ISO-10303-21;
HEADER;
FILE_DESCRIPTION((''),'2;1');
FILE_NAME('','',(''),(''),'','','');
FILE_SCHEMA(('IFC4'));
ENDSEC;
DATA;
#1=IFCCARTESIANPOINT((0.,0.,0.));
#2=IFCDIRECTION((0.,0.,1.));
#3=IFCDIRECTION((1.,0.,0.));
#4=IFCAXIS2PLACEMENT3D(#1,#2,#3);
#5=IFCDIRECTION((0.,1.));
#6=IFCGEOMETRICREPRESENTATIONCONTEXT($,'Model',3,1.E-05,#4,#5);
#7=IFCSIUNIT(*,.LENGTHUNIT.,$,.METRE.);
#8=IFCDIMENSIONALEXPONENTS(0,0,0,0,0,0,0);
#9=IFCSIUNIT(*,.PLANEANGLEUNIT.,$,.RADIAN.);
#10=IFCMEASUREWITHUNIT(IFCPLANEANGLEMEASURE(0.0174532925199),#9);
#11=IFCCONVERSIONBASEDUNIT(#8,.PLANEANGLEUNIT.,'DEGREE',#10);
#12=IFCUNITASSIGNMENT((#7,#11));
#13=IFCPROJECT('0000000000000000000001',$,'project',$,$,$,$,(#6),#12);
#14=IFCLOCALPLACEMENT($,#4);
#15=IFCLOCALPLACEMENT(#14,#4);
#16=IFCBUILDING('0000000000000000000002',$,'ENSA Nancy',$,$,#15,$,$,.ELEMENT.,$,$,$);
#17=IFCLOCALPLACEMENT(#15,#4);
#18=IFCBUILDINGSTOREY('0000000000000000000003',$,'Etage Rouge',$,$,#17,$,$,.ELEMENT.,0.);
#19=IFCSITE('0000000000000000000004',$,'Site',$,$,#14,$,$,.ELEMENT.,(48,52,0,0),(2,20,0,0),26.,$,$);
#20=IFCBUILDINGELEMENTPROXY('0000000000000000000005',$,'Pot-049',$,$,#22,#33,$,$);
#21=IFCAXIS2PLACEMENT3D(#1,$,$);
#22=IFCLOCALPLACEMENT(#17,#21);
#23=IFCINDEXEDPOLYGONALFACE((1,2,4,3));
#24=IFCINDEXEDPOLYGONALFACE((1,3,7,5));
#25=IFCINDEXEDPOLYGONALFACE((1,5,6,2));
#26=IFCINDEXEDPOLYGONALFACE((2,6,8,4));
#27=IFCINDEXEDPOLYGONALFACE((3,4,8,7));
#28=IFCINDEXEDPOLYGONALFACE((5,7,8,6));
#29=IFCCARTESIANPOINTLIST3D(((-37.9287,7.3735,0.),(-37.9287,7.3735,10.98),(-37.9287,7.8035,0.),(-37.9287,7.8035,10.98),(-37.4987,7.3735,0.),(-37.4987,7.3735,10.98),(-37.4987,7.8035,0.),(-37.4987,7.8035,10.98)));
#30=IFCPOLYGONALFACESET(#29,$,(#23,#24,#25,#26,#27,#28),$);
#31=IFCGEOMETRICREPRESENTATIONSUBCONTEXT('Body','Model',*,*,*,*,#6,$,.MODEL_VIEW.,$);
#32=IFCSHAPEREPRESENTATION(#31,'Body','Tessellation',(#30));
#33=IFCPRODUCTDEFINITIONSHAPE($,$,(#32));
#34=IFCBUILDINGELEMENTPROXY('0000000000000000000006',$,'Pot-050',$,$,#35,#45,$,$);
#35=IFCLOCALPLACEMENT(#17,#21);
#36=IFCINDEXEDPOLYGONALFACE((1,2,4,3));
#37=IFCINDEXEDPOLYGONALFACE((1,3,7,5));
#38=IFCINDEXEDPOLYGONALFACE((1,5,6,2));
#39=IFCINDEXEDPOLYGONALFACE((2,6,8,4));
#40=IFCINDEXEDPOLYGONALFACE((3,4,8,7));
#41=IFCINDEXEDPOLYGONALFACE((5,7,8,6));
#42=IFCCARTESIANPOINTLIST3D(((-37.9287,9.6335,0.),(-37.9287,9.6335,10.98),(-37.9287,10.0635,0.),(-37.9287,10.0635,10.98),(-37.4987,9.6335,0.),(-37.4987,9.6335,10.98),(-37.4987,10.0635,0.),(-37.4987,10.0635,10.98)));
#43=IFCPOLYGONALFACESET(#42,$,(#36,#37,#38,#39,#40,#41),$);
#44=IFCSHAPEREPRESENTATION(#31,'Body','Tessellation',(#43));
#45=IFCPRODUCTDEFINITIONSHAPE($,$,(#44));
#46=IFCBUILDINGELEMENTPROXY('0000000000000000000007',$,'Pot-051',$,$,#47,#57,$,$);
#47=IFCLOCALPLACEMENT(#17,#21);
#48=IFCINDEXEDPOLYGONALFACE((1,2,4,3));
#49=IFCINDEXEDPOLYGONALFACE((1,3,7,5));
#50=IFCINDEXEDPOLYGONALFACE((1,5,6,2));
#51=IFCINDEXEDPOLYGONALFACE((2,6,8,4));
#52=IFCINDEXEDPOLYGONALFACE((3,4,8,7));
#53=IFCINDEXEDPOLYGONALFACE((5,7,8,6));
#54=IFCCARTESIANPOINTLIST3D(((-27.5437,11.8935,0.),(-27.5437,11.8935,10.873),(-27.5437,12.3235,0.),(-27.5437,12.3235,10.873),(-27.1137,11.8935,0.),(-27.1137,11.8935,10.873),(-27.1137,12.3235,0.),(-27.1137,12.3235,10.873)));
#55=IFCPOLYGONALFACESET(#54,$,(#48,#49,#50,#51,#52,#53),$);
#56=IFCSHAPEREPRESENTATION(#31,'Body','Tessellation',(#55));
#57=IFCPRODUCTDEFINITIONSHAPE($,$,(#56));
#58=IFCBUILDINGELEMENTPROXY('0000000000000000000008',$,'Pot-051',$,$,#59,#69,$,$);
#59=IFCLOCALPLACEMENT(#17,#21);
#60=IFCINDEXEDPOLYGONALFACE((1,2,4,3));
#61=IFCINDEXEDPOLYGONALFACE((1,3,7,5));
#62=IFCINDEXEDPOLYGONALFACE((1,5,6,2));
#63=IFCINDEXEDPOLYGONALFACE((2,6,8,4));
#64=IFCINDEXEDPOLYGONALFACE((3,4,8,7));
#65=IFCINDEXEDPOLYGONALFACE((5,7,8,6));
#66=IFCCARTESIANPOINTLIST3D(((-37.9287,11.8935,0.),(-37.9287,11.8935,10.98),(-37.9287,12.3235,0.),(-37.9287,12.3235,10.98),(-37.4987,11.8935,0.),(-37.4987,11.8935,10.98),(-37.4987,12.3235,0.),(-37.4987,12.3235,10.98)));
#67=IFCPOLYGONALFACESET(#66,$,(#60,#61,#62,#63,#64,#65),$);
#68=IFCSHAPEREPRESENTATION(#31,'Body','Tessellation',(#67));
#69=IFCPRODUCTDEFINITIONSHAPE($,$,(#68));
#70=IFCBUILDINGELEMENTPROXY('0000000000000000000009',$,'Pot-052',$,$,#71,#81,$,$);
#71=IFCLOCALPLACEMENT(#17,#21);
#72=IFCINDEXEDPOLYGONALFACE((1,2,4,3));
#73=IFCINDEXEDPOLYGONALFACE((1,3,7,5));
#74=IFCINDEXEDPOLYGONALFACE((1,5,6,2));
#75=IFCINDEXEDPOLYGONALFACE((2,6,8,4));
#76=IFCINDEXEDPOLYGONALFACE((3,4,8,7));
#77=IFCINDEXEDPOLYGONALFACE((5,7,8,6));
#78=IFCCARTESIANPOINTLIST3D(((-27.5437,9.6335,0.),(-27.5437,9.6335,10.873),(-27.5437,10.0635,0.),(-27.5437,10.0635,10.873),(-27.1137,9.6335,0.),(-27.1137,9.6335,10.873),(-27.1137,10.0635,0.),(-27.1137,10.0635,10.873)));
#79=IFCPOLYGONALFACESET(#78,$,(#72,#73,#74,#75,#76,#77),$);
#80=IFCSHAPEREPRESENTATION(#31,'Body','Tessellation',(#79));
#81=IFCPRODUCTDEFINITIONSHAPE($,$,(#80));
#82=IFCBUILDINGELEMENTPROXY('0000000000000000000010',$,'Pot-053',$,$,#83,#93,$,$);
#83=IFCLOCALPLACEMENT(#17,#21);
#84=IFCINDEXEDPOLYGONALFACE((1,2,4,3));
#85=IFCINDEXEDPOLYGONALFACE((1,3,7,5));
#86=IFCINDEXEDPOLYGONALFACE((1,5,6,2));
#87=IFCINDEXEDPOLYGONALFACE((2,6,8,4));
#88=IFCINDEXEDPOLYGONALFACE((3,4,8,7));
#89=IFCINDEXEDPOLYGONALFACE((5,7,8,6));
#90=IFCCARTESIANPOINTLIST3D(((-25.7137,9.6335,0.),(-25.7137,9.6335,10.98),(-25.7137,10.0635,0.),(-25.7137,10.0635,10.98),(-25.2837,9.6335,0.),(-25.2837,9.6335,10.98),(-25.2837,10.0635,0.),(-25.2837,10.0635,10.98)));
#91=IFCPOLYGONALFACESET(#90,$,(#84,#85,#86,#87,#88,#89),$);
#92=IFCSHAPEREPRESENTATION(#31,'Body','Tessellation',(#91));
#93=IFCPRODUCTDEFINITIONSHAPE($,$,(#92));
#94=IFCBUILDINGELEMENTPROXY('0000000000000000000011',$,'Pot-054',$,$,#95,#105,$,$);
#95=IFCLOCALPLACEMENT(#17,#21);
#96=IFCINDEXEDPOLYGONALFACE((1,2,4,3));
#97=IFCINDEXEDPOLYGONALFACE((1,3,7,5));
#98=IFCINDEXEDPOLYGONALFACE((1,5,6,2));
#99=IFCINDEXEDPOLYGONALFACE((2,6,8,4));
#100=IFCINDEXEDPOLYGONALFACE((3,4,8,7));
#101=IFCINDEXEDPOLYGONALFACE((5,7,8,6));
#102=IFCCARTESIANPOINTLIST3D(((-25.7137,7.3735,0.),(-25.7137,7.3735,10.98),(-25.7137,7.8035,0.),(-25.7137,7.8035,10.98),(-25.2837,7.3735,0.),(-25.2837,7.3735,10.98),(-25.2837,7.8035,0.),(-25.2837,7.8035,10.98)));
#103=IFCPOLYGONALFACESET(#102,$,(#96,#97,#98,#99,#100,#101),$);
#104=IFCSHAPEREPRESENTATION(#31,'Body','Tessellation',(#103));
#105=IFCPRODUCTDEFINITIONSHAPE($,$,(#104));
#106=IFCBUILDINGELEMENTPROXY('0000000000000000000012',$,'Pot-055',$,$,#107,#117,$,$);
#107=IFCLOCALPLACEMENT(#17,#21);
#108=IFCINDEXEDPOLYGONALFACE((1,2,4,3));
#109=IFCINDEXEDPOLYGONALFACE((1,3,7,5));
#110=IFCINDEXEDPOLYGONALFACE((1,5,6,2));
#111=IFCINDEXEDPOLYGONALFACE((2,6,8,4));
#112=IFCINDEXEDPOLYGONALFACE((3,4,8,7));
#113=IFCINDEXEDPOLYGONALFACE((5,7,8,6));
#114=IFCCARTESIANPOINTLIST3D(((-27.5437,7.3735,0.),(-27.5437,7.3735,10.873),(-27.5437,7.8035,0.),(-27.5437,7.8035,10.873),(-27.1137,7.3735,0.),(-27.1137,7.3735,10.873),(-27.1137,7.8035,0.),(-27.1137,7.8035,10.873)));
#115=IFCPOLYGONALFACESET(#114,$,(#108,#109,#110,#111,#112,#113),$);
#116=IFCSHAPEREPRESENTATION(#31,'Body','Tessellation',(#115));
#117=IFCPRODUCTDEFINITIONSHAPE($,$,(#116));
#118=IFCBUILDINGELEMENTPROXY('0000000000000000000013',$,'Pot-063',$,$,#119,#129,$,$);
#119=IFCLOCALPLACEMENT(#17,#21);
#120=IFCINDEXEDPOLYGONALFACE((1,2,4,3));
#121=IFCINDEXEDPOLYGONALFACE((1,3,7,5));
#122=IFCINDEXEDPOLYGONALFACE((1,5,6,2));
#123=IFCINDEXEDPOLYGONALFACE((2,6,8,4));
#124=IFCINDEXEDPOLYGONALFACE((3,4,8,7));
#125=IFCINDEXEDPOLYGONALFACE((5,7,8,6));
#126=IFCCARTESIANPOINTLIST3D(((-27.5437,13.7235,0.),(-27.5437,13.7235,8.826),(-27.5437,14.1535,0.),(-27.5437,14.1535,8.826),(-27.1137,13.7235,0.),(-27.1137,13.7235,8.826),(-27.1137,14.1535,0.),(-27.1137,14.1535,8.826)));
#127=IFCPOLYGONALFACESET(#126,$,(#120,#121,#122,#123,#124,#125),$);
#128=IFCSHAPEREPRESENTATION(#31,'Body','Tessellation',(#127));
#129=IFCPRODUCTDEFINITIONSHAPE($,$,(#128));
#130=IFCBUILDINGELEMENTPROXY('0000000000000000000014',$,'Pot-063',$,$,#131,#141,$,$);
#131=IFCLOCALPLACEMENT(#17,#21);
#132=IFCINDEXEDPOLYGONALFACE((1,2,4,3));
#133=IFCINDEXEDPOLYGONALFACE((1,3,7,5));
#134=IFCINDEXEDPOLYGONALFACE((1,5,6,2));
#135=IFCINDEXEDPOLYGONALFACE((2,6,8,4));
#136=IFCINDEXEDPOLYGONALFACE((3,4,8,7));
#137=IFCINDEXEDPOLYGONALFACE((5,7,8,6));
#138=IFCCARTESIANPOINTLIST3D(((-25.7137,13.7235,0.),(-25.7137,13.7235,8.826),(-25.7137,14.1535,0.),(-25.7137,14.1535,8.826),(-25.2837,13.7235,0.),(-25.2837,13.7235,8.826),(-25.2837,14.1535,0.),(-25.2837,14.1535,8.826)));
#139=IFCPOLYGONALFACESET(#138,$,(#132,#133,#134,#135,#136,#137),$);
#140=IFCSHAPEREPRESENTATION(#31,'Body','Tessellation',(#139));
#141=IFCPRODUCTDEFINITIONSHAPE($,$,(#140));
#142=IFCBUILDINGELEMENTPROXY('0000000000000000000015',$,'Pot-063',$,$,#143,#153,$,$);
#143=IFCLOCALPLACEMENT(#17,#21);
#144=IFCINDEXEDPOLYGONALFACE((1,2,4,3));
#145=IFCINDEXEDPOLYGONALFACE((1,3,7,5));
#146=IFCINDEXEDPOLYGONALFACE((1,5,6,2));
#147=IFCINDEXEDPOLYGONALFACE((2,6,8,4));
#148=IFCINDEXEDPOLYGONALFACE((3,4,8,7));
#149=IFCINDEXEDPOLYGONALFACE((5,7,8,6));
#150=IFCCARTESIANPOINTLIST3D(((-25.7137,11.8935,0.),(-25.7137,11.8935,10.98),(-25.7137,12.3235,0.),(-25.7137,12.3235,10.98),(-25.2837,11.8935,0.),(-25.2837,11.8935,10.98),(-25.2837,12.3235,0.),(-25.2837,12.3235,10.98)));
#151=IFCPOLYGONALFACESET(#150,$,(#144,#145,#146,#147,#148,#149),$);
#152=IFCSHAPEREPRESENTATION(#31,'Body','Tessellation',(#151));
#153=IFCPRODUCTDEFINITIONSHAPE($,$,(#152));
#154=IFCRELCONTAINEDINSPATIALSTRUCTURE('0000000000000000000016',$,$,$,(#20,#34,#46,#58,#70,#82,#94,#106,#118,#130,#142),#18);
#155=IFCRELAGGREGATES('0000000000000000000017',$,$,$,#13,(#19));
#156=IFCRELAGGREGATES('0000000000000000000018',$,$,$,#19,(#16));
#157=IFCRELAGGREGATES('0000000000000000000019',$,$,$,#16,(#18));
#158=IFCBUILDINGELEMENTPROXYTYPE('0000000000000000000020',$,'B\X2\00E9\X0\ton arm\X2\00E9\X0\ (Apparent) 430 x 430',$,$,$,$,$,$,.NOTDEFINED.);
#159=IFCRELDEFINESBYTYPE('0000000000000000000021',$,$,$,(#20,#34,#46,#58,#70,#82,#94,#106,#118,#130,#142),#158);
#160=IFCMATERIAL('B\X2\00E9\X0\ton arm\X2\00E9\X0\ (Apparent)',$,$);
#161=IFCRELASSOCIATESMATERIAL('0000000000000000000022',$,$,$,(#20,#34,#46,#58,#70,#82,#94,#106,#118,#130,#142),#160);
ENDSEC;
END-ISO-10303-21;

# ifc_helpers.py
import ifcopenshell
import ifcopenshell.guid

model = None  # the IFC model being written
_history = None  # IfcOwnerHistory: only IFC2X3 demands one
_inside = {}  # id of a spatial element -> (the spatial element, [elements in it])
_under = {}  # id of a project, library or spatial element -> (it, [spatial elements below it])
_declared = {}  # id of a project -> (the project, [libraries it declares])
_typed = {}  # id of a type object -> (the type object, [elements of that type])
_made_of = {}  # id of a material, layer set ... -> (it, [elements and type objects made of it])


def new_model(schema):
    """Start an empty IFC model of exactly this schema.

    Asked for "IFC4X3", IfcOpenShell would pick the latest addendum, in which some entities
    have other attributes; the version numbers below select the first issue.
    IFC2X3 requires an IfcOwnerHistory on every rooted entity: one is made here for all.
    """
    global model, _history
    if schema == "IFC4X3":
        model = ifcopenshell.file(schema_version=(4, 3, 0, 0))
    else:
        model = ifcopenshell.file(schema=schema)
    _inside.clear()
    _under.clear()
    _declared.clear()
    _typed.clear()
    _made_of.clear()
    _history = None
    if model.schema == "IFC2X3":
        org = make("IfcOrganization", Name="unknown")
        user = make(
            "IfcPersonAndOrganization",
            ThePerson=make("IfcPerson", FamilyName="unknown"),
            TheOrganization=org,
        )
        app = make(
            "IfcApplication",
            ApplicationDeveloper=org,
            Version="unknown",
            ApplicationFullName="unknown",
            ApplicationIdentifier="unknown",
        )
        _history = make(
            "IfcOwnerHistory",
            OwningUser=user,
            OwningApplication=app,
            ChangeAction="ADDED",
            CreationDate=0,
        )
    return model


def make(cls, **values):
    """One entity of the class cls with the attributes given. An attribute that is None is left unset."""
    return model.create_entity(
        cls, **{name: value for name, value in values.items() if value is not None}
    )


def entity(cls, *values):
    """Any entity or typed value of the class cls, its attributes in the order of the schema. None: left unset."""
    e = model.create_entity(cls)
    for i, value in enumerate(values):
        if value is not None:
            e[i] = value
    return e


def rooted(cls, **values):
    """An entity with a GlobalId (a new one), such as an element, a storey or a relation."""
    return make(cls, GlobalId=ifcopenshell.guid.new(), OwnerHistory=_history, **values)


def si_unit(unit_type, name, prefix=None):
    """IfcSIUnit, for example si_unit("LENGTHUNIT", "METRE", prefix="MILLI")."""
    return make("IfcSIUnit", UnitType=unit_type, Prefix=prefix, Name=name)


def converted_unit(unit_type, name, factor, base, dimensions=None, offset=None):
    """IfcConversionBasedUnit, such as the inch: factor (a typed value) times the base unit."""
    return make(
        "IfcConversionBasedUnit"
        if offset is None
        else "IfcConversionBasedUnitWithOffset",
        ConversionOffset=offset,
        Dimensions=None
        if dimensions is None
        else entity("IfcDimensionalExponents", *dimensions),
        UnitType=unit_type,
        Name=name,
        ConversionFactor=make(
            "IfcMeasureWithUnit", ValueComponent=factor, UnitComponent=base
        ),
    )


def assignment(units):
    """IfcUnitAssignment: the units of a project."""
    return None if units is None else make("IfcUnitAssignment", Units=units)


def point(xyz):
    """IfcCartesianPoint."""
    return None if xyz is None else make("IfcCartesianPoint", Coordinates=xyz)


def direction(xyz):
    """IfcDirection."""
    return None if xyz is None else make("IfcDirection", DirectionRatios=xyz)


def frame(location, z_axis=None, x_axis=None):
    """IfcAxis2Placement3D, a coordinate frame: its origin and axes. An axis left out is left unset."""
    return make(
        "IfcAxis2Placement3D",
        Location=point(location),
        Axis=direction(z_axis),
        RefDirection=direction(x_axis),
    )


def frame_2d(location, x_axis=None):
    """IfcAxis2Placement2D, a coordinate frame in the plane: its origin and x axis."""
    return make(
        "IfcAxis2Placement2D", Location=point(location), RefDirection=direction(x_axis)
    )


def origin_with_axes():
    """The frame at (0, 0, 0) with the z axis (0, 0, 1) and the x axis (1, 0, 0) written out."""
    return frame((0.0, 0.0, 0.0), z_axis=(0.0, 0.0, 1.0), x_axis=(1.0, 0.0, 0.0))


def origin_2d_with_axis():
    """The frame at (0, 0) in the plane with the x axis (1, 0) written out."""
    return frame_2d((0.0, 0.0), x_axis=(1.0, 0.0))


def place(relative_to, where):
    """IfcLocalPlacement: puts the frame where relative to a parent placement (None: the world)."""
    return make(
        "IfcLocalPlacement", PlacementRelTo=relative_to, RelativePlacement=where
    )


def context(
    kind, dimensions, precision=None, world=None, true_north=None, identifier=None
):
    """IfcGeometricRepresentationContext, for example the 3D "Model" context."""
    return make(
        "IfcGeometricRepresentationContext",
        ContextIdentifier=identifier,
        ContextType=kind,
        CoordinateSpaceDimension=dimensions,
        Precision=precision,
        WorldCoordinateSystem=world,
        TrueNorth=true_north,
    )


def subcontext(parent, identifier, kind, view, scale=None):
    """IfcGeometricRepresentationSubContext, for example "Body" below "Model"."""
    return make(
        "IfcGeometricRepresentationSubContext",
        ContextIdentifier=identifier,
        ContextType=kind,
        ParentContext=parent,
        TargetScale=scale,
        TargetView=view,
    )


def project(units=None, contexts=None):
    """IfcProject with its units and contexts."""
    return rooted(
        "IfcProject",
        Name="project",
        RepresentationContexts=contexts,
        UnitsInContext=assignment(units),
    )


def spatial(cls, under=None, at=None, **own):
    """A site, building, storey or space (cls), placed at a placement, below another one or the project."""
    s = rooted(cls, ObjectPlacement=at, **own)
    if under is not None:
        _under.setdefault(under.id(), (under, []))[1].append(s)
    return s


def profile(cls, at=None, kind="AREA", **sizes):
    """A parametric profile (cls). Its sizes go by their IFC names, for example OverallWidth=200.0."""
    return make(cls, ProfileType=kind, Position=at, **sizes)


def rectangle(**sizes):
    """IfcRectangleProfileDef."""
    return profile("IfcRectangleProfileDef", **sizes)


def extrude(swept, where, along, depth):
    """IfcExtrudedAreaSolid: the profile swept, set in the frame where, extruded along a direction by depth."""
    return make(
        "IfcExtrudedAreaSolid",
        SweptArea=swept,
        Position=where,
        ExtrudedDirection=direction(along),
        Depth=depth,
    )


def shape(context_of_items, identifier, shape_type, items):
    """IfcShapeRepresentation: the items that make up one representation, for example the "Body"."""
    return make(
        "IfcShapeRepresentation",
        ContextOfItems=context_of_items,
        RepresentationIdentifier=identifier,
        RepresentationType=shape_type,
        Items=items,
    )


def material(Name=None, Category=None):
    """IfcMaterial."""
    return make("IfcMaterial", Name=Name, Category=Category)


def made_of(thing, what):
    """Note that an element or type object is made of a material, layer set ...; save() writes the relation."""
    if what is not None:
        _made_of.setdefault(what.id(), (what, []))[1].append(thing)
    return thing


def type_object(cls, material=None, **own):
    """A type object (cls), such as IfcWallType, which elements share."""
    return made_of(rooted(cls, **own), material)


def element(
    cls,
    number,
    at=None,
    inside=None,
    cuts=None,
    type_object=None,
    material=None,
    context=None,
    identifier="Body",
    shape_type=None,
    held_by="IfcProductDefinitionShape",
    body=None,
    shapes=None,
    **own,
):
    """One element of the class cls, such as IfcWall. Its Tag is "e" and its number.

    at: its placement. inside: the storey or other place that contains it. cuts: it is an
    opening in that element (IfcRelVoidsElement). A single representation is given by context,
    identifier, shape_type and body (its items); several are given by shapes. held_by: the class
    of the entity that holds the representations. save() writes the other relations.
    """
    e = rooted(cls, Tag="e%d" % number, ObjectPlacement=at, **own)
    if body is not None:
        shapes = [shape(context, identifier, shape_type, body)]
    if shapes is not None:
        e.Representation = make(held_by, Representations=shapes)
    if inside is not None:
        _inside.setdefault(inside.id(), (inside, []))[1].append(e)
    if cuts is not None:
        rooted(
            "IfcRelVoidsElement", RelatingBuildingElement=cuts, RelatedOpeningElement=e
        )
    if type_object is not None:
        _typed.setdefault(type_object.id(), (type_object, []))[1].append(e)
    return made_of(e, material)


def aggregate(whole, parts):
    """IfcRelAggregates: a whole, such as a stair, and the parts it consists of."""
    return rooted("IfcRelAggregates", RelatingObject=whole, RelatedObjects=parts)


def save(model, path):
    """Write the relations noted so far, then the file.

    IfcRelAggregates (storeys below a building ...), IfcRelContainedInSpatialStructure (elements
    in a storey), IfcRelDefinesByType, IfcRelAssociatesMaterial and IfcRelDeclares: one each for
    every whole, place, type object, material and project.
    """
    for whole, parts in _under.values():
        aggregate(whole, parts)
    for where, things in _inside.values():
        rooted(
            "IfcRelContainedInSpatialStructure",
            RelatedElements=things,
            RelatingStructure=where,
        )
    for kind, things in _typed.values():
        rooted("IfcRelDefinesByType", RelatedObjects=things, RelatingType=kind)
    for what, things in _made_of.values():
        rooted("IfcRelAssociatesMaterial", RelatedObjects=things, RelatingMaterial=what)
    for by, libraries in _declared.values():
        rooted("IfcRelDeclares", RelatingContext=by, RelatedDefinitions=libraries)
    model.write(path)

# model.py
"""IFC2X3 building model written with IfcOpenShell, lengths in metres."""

from ifc_helpers import new_model, entity, si_unit, converted_unit, direction, frame, origin_with_axes, origin_2d_with_axis, place, context, subcontext, project, spatial, rectangle, extrude, material, type_object, element, save


model = new_model("IFC2X3")

# Units and contexts
model_context = context("Model", 3, precision=1e-05, world=origin_with_axes(), true_north=direction((0.0, 1.0)))
body_context = subcontext(model_context, "Body", "Model", "MODEL_VIEW")
ifc_project = project(units=[si_unit("LENGTHUNIT", "METRE"), converted_unit("PLANEANGLEUNIT", "DEGREE", entity("IfcPlaneAngleMeasure", 0.0174532925199), si_unit("PLANEANGLEUNIT", "RADIAN"), dimensions=[0, 0, 0, 0, 0, 0, 0])], contexts=[model_context])

# Site, building, storey
site_placement = place(None, origin_with_axes())
site = spatial("IfcSite", under=ifc_project, at=site_placement, Name="Site", CompositionType="ELEMENT", RefLatitude=(48, 52, 0, 0), RefLongitude=(2, 20, 0, 0), RefElevation=26.0)
building_placement = place(site_placement, origin_with_axes())
building = spatial("IfcBuilding", under=site, at=building_placement, Name="ENSA Nancy", CompositionType="ELEMENT")
storey_placement = place(building_placement, origin_with_axes())
storey = spatial("IfcBuildingStorey", under=building, at=storey_placement, Name="Etage Rouge", CompositionType="ELEMENT", Elevation=0.0)

# Building element proxies
ifc_material_1 = material(Name="Béton armé (Apparent)")
building_element_proxy_type_1 = type_object("IfcBuildingElementProxyType", Name="Béton armé (Apparent) 430 x 430", PredefinedType="NOTDEFINED")
for number, where, z_axis, x_axis, name in (
    (1, (-37.7137, 7.5885, 0.0), (0.0, 0.0, 1.0), (1.0, 0.0, 0.0), "Pot-049"),
    (2, (-37.7137, 9.8485, 0.0), (0.0, 0.0, 1.0), (1.0, 0.0, 0.0), "Pot-050"),
):
    element("IfcBuildingElementProxy", number, at=place(storey_placement, frame(where, z_axis=z_axis, x_axis=x_axis)), inside=storey, type_object=building_element_proxy_type_1, material=ifc_material_1, Name=name, context=body_context, shape_type="SweptSolid", body=[
        extrude(rectangle(XDim=0.43, YDim=0.43, at=origin_2d_with_axis()), origin_with_axes(), (0.0, 0.0, 1.0), 10.98),
    ])
proxy_1_placement = place(storey_placement, frame((-27.3287, 12.1085, 0.0), z_axis=(0.0, 0.0, 1.0), x_axis=(1.0, 0.0, 0.0)))
element("IfcBuildingElementProxy", 3, at=proxy_1_placement, inside=storey, type_object=building_element_proxy_type_1, material=ifc_material_1, Name="Pot-051", context=body_context, shape_type="SweptSolid", body=[
    extrude(rectangle(XDim=0.43, YDim=0.43, at=origin_2d_with_axis()), origin_with_axes(), (0.0, 0.0, 1.0), 10.873),
])
proxy_2_placement = place(storey_placement, frame((-37.7137, 12.1085, 0.0), z_axis=(0.0, 0.0, 1.0), x_axis=(1.0, 0.0, 0.0)))
element("IfcBuildingElementProxy", 4, at=proxy_2_placement, inside=storey, type_object=building_element_proxy_type_1, material=ifc_material_1, Name="Pot-051", context=body_context, shape_type="SweptSolid", body=[
    extrude(rectangle(XDim=0.43, YDim=0.43, at=origin_2d_with_axis()), origin_with_axes(), (0.0, 0.0, 1.0), 10.98),
])
proxy_3_placement = place(storey_placement, frame((-27.3287, 9.8485, 0.0), z_axis=(0.0, 0.0, 1.0), x_axis=(1.0, 0.0, 0.0)))
element("IfcBuildingElementProxy", 5, at=proxy_3_placement, inside=storey, type_object=building_element_proxy_type_1, material=ifc_material_1, Name="Pot-052", context=body_context, shape_type="SweptSolid", body=[
    extrude(rectangle(XDim=0.43, YDim=0.43, at=origin_2d_with_axis()), origin_with_axes(), (0.0, 0.0, 1.0), 10.873),
])
for number, where, z_axis, x_axis, name in (
    (6, (-25.4987, 9.8485, 0.0), (0.0, 0.0, 1.0), (1.0, 0.0, 0.0), "Pot-053"),
    (7, (-25.4987, 7.5885, 0.0), (0.0, 0.0, 1.0), (1.0, 0.0, 0.0), "Pot-054"),
):
    element("IfcBuildingElementProxy", number, at=place(storey_placement, frame(where, z_axis=z_axis, x_axis=x_axis)), inside=storey, type_object=building_element_proxy_type_1, material=ifc_material_1, Name=name, context=body_context, shape_type="SweptSolid", body=[
        extrude(rectangle(XDim=0.43, YDim=0.43, at=origin_2d_with_axis()), origin_with_axes(), (0.0, 0.0, 1.0), 10.98),
    ])
proxy_4_placement = place(storey_placement, frame((-27.3287, 7.5885, 0.0), z_axis=(0.0, 0.0, 1.0), x_axis=(1.0, 0.0, 0.0)))
element("IfcBuildingElementProxy", 8, at=proxy_4_placement, inside=storey, type_object=building_element_proxy_type_1, material=ifc_material_1, Name="Pot-055", context=body_context, shape_type="SweptSolid", body=[
    extrude(rectangle(XDim=0.43, YDim=0.43, at=origin_2d_with_axis()), origin_with_axes(), (0.0, 0.0, 1.0), 10.873),
])
for number, where, z_axis, x_axis, name in (
    (9, (-27.3287, 13.9385, 0.0), (0.0, 0.0, 1.0), (1.0, 0.0, 0.0), "Pot-063"),
    (10, (-25.4987, 13.9385, 0.0), (0.0, 0.0, 1.0), (1.0, 0.0, 0.0), "Pot-063"),
):
    element("IfcBuildingElementProxy", number, at=place(storey_placement, frame(where, z_axis=z_axis, x_axis=x_axis)), inside=storey, type_object=building_element_proxy_type_1, material=ifc_material_1, Name=name, context=body_context, shape_type="SweptSolid", body=[
        extrude(rectangle(XDim=0.43, YDim=0.43, at=origin_2d_with_axis()), origin_with_axes(), (0.0, 0.0, 1.0), 8.826),
    ])
proxy_5_placement = place(storey_placement, frame((-25.4987, 12.1085, 0.0), z_axis=(0.0, 0.0, 1.0), x_axis=(1.0, 0.0, 0.0)))
element("IfcBuildingElementProxy", 11, at=proxy_5_placement, inside=storey, type_object=building_element_proxy_type_1, material=ifc_material_1, Name="Pot-063", context=body_context, shape_type="SweptSolid", body=[
    extrude(rectangle(XDim=0.43, YDim=0.43, at=origin_2d_with_axis()), origin_with_axes(), (0.0, 0.0, 1.0), 10.98),
])

save(model, "model.ifc")
